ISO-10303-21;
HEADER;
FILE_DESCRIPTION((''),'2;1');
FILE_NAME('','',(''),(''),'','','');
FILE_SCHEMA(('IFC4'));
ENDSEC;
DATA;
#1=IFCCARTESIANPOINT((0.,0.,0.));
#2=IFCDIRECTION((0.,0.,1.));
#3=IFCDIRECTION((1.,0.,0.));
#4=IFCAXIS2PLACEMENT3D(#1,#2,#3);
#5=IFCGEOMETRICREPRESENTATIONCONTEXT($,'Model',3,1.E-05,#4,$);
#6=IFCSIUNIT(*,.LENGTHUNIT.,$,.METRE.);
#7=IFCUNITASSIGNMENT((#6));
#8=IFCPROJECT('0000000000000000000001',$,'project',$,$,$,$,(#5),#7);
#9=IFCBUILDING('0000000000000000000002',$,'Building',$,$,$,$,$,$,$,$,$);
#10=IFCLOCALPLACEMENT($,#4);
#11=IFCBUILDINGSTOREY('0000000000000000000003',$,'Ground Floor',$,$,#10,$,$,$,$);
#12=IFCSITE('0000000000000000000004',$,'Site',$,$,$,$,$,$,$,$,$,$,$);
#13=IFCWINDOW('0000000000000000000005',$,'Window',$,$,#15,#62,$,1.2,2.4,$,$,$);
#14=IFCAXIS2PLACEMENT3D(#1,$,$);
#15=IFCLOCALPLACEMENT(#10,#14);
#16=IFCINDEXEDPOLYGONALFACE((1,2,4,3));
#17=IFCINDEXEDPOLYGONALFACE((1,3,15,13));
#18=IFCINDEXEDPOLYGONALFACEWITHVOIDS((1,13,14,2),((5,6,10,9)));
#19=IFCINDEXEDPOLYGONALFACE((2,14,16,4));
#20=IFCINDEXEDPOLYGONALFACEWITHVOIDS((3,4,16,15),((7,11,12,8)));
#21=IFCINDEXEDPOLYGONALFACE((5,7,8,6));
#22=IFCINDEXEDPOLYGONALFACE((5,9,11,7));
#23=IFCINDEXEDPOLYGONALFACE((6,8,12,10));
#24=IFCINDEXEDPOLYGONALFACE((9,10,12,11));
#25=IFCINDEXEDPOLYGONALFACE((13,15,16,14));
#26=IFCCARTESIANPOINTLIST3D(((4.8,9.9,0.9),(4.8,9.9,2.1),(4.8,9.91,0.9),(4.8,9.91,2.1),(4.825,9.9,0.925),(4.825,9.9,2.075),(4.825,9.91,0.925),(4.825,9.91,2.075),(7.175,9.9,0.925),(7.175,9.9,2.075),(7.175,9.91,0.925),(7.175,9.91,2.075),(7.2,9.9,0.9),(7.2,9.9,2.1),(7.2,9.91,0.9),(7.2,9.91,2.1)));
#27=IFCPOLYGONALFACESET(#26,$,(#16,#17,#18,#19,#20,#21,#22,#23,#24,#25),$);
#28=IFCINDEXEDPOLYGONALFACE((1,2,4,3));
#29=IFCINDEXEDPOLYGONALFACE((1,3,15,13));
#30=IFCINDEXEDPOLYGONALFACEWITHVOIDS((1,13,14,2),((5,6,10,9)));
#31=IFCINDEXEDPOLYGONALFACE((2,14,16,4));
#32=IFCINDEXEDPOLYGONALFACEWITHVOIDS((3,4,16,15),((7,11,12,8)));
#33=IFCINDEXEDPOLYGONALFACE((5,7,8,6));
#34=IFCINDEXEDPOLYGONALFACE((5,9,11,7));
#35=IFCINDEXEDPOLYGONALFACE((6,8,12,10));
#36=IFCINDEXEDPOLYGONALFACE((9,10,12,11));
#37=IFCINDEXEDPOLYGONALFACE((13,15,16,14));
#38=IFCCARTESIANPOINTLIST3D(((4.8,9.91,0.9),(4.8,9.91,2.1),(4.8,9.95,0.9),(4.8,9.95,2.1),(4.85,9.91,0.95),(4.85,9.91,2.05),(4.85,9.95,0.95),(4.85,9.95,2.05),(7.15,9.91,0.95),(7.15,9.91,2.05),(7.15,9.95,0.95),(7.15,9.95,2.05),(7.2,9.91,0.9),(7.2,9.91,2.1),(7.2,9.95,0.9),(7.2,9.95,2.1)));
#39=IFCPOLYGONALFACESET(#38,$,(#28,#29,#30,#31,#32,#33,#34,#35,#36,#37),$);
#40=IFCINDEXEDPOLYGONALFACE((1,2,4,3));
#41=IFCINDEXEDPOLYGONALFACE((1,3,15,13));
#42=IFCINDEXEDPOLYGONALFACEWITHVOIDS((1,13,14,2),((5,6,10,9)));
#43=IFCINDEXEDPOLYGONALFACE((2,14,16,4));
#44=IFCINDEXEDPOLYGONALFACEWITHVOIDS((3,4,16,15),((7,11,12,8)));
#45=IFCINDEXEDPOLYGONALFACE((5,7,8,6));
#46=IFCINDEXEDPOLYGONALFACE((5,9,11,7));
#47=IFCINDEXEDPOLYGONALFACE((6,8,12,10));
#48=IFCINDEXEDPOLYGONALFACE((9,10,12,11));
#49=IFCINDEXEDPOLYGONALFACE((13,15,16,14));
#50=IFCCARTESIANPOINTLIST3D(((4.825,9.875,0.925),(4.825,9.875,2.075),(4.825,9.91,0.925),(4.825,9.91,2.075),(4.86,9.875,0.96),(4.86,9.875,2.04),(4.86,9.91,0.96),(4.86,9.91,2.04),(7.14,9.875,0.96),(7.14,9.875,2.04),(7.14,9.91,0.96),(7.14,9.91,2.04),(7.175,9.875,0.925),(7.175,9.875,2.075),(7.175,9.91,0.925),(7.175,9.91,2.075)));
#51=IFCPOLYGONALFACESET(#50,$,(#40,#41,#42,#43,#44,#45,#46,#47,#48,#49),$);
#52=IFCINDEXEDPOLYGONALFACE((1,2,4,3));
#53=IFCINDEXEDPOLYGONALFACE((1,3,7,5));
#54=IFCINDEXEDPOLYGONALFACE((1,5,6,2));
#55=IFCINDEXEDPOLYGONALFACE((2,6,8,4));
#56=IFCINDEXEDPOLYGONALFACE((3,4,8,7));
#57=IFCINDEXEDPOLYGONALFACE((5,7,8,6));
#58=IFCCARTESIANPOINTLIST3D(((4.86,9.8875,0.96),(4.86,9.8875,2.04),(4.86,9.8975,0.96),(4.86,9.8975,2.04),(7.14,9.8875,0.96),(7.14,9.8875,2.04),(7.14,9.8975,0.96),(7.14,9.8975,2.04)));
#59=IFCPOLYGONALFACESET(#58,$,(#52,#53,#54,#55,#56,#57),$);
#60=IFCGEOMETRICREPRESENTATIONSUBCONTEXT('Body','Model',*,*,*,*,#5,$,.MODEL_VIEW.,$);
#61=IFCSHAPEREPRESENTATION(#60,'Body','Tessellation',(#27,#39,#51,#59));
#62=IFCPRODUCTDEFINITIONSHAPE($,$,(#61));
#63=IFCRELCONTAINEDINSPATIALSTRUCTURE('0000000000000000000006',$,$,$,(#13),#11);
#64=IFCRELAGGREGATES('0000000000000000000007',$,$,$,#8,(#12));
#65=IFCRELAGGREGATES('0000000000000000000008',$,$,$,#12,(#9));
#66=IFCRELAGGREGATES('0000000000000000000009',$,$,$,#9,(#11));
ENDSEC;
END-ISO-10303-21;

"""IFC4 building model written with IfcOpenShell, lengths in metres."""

from ifc_helpers import new_model, si_unit, frame, origin_with_axes, place, context, subcontext, project, spatial, line, indexed_curve, outline, extrude, element, save


model = new_model("IFC4")

# Units and contexts
model_context = context("Model", 3, precision=1e-05, world=origin_with_axes())
body_context = subcontext(model_context, "Body", "Model", "MODEL_VIEW")
ifc_project = project(units=[si_unit("LENGTHUNIT", "METRE")], contexts=[model_context])

# Site, building, storey
site = spatial("IfcSite", under=ifc_project, Name="Site")
building = spatial("IfcBuilding", under=site, Name="Building")
storey_placement = place(None, origin_with_axes())
storey = spatial("IfcBuildingStorey", under=building, at=storey_placement, Name="Ground Floor")

# Window
window_1_placement = place(storey_placement, frame((7.2, 10.0, 0.9), z_axis=(0.0, 0.0, 1.0), x_axis=(-1.0, 0.0, 0.0)))
element("IfcWindow", 1, at=window_1_placement, inside=storey, Name="Window", OverallHeight=1.2, OverallWidth=2.4, context=body_context, shape_type="SweptSolid", body=[
    extrude(outline(indexed_curve([(0.0, 0.0), (2.4, 0.0), (2.4, 1.2), (0.0, 1.2)], segments=[line(1, 2, 3, 4, 1)]), holes=[indexed_curve([(0.025, 0.025), (2.375, 0.025), (2.375, 1.175), (0.025, 1.175)], segments=[line(1, 2, 3, 4, 1)])]), frame((0.0, 0.09, 0.0), z_axis=(0.0, -1.0, 0.0), x_axis=(1.0, 0.0, 0.0)), (0.0, 0.0, -1.0), 0.01),
    extrude(outline(indexed_curve([(0.0, 0.0), (2.4, 0.0), (2.4, 1.2), (0.0, 1.2)], segments=[line(1, 2, 3, 4, 1)]), holes=[indexed_curve([(0.05, 0.05), (2.35, 0.05), (2.35, 1.15), (0.05, 1.15)], segments=[line(1, 2, 3, 4, 1)])]), frame((0.0, 0.05, 0.0), z_axis=(0.0, -1.0, 0.0), x_axis=(1.0, 0.0, 0.0)), (0.0, 0.0, -1.0), 0.04),
    extrude(outline(indexed_curve([(0.0, 0.0), (2.35, 0.0), (2.35, 1.15), (0.0, 1.15)], segments=[line(1, 2, 3, 4, 1)]), holes=[indexed_curve([(0.035, 0.035), (2.315, 0.035), (2.315, 1.115), (0.035, 1.115)], segments=[line(1, 2, 3, 4, 1)])]), frame((0.025, 0.09, 0.025), z_axis=(0.0, -1.0, 0.0), x_axis=(1.0, 0.0, 0.0)), (0.0, 0.0, -1.0), 0.035),
    extrude(outline(indexed_curve([(0.035, 0.035), (2.315, 0.035), (2.315, 1.115), (0.035, 1.115)], segments=[line(1, 2, 3, 4, 1)])), frame((0.025, 0.1025, 0.025), z_axis=(0.0, -1.0, 0.0), x_axis=(1.0, 0.0, 0.0)), (0.0, 0.0, -1.0), 0.01),
])

save(model, "model.ifc")
